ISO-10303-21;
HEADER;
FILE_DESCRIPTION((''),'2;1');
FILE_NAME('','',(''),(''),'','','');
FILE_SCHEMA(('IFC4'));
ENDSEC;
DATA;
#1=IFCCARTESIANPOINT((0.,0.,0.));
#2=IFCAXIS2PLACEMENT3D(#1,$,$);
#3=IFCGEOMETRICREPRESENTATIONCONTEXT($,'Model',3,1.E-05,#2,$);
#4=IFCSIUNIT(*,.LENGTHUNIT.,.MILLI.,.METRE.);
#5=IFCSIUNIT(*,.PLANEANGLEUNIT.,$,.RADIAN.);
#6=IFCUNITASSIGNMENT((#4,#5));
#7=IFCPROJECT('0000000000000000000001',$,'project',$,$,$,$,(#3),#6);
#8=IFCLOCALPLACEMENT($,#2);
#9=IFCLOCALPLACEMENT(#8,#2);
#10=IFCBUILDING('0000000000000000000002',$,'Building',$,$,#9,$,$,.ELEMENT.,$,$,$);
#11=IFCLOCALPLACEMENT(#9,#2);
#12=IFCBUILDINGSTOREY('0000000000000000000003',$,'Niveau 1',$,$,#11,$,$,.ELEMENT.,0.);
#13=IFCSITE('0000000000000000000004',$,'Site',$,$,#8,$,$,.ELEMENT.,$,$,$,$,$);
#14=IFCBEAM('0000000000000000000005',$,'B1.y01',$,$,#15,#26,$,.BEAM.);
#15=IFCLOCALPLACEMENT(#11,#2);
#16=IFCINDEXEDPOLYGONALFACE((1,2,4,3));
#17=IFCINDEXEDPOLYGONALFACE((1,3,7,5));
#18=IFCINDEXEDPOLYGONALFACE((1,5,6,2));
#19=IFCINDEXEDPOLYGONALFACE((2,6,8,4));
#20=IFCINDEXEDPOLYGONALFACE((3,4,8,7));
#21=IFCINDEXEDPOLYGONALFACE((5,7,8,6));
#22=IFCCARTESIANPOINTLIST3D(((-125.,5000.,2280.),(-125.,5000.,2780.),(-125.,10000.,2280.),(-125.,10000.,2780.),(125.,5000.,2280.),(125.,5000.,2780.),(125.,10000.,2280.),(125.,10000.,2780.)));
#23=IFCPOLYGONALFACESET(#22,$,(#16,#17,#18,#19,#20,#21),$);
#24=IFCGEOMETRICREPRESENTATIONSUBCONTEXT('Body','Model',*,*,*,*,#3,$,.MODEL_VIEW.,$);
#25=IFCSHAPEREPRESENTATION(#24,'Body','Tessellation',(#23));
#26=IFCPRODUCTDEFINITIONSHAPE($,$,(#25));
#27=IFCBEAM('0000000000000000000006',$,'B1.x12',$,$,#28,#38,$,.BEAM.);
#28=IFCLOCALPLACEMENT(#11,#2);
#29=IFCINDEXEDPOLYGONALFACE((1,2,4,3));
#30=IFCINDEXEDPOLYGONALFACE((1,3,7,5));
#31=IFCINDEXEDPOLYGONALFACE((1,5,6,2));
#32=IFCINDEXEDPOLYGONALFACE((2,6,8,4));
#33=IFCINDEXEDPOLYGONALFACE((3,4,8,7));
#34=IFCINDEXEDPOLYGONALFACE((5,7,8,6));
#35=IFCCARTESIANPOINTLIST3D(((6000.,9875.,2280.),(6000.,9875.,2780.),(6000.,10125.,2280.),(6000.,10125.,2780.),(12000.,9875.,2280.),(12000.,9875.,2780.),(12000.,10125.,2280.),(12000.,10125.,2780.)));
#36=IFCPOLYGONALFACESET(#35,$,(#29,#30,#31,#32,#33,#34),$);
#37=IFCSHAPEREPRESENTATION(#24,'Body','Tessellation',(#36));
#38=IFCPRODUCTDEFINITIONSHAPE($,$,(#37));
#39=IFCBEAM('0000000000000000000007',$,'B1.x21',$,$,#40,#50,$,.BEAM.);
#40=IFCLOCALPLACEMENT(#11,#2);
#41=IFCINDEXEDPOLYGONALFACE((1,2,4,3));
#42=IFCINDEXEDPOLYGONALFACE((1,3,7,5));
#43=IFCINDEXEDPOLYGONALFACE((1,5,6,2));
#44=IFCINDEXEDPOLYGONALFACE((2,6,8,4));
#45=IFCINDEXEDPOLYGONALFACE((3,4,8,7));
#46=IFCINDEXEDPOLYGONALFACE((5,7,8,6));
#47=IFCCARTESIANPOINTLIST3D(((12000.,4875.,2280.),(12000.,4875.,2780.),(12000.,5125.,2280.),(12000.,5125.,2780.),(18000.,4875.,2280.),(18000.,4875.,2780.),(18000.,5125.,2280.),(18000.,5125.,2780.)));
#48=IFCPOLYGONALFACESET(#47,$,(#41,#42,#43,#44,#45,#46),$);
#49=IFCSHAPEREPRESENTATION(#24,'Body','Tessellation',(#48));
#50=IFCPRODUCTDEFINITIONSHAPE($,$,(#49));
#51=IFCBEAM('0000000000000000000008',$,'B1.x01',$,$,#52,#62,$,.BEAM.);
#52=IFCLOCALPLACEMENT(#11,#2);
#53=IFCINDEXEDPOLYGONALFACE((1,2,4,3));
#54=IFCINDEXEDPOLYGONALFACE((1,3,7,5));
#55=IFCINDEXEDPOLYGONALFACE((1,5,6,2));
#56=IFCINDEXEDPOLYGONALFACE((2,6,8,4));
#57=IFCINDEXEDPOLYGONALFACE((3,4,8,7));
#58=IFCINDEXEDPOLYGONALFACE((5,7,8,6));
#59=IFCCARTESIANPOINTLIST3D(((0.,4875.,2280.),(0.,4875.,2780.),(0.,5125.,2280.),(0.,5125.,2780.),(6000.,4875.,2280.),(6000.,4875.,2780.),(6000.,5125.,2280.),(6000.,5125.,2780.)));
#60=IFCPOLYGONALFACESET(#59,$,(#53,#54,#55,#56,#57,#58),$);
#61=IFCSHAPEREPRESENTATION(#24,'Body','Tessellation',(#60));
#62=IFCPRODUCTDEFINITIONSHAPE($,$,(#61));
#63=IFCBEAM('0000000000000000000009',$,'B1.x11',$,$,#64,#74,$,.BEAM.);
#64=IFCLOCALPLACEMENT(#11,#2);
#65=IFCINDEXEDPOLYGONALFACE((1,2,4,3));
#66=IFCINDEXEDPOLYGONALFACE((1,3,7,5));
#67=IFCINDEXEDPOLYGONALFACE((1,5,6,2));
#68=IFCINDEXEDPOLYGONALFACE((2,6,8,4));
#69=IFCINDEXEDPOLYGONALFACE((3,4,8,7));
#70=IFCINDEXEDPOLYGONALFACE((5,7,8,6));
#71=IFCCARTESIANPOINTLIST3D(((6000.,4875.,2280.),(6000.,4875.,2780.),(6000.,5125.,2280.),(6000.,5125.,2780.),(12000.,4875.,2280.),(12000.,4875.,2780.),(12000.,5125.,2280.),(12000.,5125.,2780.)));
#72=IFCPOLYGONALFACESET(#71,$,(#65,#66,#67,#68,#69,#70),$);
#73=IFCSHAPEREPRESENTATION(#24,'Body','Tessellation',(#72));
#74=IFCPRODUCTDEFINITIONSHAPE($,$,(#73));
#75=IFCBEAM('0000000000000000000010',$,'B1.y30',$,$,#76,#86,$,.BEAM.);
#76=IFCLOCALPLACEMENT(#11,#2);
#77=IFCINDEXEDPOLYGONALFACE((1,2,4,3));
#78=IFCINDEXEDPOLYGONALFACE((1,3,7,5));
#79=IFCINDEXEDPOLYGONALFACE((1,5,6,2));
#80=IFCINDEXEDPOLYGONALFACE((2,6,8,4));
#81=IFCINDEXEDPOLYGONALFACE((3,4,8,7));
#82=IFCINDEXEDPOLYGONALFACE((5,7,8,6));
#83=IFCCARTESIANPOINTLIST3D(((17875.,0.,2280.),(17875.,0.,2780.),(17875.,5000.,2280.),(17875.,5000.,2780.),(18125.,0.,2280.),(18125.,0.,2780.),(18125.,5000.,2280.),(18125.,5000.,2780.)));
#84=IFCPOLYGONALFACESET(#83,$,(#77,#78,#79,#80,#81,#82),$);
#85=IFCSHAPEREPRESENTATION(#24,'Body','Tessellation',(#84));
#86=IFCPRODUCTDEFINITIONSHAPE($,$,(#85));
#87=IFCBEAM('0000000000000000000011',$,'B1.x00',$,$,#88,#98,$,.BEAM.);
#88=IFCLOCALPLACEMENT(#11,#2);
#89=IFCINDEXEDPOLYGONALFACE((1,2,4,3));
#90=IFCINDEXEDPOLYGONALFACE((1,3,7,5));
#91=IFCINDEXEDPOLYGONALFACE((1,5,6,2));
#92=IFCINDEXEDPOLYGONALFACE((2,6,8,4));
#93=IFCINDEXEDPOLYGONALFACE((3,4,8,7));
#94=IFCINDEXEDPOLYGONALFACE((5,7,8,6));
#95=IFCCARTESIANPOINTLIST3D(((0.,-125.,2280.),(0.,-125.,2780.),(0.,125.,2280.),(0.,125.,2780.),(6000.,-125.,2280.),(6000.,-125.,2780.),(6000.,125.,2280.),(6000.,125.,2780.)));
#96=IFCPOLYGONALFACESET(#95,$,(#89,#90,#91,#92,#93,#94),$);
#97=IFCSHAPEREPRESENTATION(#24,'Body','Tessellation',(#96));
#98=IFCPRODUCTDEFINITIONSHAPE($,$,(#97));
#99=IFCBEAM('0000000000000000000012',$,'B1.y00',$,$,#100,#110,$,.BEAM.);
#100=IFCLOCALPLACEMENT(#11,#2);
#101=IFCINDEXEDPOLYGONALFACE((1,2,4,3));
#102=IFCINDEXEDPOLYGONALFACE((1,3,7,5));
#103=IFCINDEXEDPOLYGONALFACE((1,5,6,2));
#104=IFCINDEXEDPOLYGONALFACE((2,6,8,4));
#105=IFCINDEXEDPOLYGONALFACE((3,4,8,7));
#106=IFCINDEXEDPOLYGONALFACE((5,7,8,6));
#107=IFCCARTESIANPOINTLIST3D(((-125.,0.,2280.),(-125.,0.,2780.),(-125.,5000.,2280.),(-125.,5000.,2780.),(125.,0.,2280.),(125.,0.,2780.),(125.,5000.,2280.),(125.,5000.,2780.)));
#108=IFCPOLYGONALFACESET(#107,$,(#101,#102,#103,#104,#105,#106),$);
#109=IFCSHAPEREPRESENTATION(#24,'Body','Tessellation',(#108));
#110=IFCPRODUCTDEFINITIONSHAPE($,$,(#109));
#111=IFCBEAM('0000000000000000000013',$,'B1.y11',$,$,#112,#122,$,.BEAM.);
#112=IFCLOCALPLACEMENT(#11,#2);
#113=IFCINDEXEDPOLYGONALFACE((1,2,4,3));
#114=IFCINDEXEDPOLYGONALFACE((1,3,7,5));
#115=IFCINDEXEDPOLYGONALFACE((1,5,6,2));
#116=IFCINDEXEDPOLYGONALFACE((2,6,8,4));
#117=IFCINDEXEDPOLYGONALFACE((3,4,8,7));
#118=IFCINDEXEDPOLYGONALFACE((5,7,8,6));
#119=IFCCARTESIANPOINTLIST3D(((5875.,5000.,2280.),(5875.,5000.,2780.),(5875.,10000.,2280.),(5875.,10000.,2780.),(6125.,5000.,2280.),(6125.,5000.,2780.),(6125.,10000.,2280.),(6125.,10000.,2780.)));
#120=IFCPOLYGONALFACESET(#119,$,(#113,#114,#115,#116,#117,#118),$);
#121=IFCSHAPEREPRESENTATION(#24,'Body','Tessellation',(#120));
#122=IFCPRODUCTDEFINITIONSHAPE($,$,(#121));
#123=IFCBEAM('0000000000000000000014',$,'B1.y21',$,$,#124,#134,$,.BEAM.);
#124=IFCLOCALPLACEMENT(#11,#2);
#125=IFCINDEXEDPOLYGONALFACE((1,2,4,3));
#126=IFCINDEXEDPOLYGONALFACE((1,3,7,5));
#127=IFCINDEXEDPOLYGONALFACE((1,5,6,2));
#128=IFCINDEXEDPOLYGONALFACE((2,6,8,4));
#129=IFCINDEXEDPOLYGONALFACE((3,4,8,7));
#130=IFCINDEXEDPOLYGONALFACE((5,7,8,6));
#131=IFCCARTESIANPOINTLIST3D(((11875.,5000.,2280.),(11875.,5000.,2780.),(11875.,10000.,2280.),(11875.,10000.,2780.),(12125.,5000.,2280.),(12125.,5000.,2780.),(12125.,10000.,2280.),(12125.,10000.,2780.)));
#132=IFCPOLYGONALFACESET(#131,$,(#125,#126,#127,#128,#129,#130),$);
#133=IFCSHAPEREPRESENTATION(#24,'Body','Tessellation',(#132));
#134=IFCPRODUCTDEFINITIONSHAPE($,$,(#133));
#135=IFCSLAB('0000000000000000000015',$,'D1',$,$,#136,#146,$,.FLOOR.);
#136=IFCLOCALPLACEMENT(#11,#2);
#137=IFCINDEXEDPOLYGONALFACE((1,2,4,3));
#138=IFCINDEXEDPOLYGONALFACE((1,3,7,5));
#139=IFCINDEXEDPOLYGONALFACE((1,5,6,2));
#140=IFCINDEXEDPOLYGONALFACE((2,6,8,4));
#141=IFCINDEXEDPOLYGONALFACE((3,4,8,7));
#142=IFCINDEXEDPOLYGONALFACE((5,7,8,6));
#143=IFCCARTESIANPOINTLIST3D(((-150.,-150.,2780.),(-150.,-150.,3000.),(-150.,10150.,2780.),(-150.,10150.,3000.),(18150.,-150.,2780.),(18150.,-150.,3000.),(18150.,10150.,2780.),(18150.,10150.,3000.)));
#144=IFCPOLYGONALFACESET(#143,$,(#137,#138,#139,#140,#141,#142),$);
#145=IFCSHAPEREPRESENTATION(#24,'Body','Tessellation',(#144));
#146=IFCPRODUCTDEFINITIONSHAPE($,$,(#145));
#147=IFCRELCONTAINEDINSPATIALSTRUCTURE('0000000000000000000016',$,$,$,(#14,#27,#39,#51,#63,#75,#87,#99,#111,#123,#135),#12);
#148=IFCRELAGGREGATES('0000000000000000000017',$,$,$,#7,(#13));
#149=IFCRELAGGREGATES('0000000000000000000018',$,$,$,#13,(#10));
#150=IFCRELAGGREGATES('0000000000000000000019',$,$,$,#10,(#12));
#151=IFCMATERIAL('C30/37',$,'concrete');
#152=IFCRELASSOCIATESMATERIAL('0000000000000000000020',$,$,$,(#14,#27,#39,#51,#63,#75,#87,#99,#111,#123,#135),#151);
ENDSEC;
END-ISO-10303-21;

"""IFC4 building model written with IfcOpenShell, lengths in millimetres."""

from ifc_helpers import new_model, si_unit, frame, origin, place, context, subcontext, project, spatial, polyline, rectangle, outline, extrude, material, element, save


model = new_model("IFC4")

# Units and contexts
model_context = context("Model", 3, precision=1e-05, world=origin())
body_context = subcontext(model_context, "Body", "Model", "MODEL_VIEW")
ifc_project = project(units=[si_unit("LENGTHUNIT", "METRE", prefix="MILLI"), si_unit("PLANEANGLEUNIT", "RADIAN")], contexts=[model_context])

# Site, building, storey
site_placement = place(None, origin())
site = spatial("IfcSite", under=ifc_project, at=site_placement, Name="Site", CompositionType="ELEMENT")
building_placement = place(site_placement, origin())
building = spatial("IfcBuilding", under=site, at=building_placement, Name="Building", CompositionType="ELEMENT")
storey_placement = place(building_placement, origin())
storey = spatial("IfcBuildingStorey", under=building, at=storey_placement, Name="Niveau 1", CompositionType="ELEMENT", Elevation=0.0)

# Shared definitions
ifc_material = material(Name="C30/37", Category="concrete")

# Beams
beam_1_placement = place(storey_placement, frame((0.0, 5000.0, 2530.0), z_axis=(0.0, 1.0, 0.0), x_axis=(-1.0, 0.0, 0.0)))
element("IfcBeam", 1, at=beam_1_placement, inside=storey, material=ifc_material, Name="B1.y01", PredefinedType="BEAM", context=body_context, shape_type="SweptSolid", body=[
    extrude(rectangle(XDim=250.0, YDim=500.0), origin(), (0.0, 0.0, 1.0), 5000.0),
])
for number, where, z_axis, x_axis, name in (
    (2, (6000.0, 10000.0, 2530.0), (1.0, 0.0, 0.0), (0.0, 1.0, 0.0), "B1.x12"),
    (3, (12000.0, 5000.0, 2530.0), (1.0, 0.0, 0.0), (0.0, 1.0, 0.0), "B1.x21"),
    (4, (0.0, 5000.0, 2530.0), (1.0, 0.0, 0.0), (0.0, 1.0, 0.0), "B1.x01"),
    (5, (6000.0, 5000.0, 2530.0), (1.0, 0.0, 0.0), (0.0, 1.0, 0.0), "B1.x11"),
):
    element("IfcBeam", number, at=place(storey_placement, frame(where, z_axis=z_axis, x_axis=x_axis)), inside=storey, material=ifc_material, Name=name, PredefinedType="BEAM", context=body_context, shape_type="SweptSolid", body=[
        extrude(rectangle(XDim=250.0, YDim=500.0), origin(), (0.0, 0.0, 1.0), 6000.0),
    ])
beam_2_placement = place(storey_placement, frame((18000.0, 0.0, 2530.0), z_axis=(0.0, 1.0, 0.0), x_axis=(-1.0, 0.0, 0.0)))
element("IfcBeam", 6, at=beam_2_placement, inside=storey, material=ifc_material, Name="B1.y30", PredefinedType="BEAM", context=body_context, shape_type="SweptSolid", body=[
    extrude(rectangle(XDim=250.0, YDim=500.0), origin(), (0.0, 0.0, 1.0), 5000.0),
])
beam_3_placement = place(storey_placement, frame((0.0, 0.0, 2530.0), z_axis=(1.0, 0.0, 0.0), x_axis=(0.0, 1.0, 0.0)))
element("IfcBeam", 7, at=beam_3_placement, inside=storey, material=ifc_material, Name="B1.x00", PredefinedType="BEAM", context=body_context, shape_type="SweptSolid", body=[
    extrude(rectangle(XDim=250.0, YDim=500.0), origin(), (0.0, 0.0, 1.0), 6000.0),
])
for number, where, z_axis, x_axis, name in (
    (8, (0.0, 0.0, 2530.0), (0.0, 1.0, 0.0), (-1.0, 0.0, 0.0), "B1.y00"),
    (9, (6000.0, 5000.0, 2530.0), (0.0, 1.0, 0.0), (-1.0, 0.0, 0.0), "B1.y11"),
    (10, (12000.0, 5000.0, 2530.0), (0.0, 1.0, 0.0), (-1.0, 0.0, 0.0), "B1.y21"),
):
    element("IfcBeam", number, at=place(storey_placement, frame(where, z_axis=z_axis, x_axis=x_axis)), inside=storey, material=ifc_material, Name=name, PredefinedType="BEAM", context=body_context, shape_type="SweptSolid", body=[
        extrude(rectangle(XDim=250.0, YDim=500.0), origin(), (0.0, 0.0, 1.0), 5000.0),
    ])

# Slab
slab_placement = place(storey_placement, frame((0.0, 0.0, 2780.0), z_axis=(0.0, 0.0, 1.0), x_axis=(1.0, 0.0, 0.0)))
element("IfcSlab", 11, at=slab_placement, inside=storey, material=ifc_material, Name="D1", PredefinedType="FLOOR", context=body_context, shape_type="SweptSolid", body=[
    extrude(outline(polyline([(-150.0, -150.0), (18150.0, -150.0), (18150.0, 10150.0), (-150.0, 10150.0), (-150.0, -150.0)])), origin(), (0.0, 0.0, 1.0), 220.0),
])

save(model, "model.ifc")
